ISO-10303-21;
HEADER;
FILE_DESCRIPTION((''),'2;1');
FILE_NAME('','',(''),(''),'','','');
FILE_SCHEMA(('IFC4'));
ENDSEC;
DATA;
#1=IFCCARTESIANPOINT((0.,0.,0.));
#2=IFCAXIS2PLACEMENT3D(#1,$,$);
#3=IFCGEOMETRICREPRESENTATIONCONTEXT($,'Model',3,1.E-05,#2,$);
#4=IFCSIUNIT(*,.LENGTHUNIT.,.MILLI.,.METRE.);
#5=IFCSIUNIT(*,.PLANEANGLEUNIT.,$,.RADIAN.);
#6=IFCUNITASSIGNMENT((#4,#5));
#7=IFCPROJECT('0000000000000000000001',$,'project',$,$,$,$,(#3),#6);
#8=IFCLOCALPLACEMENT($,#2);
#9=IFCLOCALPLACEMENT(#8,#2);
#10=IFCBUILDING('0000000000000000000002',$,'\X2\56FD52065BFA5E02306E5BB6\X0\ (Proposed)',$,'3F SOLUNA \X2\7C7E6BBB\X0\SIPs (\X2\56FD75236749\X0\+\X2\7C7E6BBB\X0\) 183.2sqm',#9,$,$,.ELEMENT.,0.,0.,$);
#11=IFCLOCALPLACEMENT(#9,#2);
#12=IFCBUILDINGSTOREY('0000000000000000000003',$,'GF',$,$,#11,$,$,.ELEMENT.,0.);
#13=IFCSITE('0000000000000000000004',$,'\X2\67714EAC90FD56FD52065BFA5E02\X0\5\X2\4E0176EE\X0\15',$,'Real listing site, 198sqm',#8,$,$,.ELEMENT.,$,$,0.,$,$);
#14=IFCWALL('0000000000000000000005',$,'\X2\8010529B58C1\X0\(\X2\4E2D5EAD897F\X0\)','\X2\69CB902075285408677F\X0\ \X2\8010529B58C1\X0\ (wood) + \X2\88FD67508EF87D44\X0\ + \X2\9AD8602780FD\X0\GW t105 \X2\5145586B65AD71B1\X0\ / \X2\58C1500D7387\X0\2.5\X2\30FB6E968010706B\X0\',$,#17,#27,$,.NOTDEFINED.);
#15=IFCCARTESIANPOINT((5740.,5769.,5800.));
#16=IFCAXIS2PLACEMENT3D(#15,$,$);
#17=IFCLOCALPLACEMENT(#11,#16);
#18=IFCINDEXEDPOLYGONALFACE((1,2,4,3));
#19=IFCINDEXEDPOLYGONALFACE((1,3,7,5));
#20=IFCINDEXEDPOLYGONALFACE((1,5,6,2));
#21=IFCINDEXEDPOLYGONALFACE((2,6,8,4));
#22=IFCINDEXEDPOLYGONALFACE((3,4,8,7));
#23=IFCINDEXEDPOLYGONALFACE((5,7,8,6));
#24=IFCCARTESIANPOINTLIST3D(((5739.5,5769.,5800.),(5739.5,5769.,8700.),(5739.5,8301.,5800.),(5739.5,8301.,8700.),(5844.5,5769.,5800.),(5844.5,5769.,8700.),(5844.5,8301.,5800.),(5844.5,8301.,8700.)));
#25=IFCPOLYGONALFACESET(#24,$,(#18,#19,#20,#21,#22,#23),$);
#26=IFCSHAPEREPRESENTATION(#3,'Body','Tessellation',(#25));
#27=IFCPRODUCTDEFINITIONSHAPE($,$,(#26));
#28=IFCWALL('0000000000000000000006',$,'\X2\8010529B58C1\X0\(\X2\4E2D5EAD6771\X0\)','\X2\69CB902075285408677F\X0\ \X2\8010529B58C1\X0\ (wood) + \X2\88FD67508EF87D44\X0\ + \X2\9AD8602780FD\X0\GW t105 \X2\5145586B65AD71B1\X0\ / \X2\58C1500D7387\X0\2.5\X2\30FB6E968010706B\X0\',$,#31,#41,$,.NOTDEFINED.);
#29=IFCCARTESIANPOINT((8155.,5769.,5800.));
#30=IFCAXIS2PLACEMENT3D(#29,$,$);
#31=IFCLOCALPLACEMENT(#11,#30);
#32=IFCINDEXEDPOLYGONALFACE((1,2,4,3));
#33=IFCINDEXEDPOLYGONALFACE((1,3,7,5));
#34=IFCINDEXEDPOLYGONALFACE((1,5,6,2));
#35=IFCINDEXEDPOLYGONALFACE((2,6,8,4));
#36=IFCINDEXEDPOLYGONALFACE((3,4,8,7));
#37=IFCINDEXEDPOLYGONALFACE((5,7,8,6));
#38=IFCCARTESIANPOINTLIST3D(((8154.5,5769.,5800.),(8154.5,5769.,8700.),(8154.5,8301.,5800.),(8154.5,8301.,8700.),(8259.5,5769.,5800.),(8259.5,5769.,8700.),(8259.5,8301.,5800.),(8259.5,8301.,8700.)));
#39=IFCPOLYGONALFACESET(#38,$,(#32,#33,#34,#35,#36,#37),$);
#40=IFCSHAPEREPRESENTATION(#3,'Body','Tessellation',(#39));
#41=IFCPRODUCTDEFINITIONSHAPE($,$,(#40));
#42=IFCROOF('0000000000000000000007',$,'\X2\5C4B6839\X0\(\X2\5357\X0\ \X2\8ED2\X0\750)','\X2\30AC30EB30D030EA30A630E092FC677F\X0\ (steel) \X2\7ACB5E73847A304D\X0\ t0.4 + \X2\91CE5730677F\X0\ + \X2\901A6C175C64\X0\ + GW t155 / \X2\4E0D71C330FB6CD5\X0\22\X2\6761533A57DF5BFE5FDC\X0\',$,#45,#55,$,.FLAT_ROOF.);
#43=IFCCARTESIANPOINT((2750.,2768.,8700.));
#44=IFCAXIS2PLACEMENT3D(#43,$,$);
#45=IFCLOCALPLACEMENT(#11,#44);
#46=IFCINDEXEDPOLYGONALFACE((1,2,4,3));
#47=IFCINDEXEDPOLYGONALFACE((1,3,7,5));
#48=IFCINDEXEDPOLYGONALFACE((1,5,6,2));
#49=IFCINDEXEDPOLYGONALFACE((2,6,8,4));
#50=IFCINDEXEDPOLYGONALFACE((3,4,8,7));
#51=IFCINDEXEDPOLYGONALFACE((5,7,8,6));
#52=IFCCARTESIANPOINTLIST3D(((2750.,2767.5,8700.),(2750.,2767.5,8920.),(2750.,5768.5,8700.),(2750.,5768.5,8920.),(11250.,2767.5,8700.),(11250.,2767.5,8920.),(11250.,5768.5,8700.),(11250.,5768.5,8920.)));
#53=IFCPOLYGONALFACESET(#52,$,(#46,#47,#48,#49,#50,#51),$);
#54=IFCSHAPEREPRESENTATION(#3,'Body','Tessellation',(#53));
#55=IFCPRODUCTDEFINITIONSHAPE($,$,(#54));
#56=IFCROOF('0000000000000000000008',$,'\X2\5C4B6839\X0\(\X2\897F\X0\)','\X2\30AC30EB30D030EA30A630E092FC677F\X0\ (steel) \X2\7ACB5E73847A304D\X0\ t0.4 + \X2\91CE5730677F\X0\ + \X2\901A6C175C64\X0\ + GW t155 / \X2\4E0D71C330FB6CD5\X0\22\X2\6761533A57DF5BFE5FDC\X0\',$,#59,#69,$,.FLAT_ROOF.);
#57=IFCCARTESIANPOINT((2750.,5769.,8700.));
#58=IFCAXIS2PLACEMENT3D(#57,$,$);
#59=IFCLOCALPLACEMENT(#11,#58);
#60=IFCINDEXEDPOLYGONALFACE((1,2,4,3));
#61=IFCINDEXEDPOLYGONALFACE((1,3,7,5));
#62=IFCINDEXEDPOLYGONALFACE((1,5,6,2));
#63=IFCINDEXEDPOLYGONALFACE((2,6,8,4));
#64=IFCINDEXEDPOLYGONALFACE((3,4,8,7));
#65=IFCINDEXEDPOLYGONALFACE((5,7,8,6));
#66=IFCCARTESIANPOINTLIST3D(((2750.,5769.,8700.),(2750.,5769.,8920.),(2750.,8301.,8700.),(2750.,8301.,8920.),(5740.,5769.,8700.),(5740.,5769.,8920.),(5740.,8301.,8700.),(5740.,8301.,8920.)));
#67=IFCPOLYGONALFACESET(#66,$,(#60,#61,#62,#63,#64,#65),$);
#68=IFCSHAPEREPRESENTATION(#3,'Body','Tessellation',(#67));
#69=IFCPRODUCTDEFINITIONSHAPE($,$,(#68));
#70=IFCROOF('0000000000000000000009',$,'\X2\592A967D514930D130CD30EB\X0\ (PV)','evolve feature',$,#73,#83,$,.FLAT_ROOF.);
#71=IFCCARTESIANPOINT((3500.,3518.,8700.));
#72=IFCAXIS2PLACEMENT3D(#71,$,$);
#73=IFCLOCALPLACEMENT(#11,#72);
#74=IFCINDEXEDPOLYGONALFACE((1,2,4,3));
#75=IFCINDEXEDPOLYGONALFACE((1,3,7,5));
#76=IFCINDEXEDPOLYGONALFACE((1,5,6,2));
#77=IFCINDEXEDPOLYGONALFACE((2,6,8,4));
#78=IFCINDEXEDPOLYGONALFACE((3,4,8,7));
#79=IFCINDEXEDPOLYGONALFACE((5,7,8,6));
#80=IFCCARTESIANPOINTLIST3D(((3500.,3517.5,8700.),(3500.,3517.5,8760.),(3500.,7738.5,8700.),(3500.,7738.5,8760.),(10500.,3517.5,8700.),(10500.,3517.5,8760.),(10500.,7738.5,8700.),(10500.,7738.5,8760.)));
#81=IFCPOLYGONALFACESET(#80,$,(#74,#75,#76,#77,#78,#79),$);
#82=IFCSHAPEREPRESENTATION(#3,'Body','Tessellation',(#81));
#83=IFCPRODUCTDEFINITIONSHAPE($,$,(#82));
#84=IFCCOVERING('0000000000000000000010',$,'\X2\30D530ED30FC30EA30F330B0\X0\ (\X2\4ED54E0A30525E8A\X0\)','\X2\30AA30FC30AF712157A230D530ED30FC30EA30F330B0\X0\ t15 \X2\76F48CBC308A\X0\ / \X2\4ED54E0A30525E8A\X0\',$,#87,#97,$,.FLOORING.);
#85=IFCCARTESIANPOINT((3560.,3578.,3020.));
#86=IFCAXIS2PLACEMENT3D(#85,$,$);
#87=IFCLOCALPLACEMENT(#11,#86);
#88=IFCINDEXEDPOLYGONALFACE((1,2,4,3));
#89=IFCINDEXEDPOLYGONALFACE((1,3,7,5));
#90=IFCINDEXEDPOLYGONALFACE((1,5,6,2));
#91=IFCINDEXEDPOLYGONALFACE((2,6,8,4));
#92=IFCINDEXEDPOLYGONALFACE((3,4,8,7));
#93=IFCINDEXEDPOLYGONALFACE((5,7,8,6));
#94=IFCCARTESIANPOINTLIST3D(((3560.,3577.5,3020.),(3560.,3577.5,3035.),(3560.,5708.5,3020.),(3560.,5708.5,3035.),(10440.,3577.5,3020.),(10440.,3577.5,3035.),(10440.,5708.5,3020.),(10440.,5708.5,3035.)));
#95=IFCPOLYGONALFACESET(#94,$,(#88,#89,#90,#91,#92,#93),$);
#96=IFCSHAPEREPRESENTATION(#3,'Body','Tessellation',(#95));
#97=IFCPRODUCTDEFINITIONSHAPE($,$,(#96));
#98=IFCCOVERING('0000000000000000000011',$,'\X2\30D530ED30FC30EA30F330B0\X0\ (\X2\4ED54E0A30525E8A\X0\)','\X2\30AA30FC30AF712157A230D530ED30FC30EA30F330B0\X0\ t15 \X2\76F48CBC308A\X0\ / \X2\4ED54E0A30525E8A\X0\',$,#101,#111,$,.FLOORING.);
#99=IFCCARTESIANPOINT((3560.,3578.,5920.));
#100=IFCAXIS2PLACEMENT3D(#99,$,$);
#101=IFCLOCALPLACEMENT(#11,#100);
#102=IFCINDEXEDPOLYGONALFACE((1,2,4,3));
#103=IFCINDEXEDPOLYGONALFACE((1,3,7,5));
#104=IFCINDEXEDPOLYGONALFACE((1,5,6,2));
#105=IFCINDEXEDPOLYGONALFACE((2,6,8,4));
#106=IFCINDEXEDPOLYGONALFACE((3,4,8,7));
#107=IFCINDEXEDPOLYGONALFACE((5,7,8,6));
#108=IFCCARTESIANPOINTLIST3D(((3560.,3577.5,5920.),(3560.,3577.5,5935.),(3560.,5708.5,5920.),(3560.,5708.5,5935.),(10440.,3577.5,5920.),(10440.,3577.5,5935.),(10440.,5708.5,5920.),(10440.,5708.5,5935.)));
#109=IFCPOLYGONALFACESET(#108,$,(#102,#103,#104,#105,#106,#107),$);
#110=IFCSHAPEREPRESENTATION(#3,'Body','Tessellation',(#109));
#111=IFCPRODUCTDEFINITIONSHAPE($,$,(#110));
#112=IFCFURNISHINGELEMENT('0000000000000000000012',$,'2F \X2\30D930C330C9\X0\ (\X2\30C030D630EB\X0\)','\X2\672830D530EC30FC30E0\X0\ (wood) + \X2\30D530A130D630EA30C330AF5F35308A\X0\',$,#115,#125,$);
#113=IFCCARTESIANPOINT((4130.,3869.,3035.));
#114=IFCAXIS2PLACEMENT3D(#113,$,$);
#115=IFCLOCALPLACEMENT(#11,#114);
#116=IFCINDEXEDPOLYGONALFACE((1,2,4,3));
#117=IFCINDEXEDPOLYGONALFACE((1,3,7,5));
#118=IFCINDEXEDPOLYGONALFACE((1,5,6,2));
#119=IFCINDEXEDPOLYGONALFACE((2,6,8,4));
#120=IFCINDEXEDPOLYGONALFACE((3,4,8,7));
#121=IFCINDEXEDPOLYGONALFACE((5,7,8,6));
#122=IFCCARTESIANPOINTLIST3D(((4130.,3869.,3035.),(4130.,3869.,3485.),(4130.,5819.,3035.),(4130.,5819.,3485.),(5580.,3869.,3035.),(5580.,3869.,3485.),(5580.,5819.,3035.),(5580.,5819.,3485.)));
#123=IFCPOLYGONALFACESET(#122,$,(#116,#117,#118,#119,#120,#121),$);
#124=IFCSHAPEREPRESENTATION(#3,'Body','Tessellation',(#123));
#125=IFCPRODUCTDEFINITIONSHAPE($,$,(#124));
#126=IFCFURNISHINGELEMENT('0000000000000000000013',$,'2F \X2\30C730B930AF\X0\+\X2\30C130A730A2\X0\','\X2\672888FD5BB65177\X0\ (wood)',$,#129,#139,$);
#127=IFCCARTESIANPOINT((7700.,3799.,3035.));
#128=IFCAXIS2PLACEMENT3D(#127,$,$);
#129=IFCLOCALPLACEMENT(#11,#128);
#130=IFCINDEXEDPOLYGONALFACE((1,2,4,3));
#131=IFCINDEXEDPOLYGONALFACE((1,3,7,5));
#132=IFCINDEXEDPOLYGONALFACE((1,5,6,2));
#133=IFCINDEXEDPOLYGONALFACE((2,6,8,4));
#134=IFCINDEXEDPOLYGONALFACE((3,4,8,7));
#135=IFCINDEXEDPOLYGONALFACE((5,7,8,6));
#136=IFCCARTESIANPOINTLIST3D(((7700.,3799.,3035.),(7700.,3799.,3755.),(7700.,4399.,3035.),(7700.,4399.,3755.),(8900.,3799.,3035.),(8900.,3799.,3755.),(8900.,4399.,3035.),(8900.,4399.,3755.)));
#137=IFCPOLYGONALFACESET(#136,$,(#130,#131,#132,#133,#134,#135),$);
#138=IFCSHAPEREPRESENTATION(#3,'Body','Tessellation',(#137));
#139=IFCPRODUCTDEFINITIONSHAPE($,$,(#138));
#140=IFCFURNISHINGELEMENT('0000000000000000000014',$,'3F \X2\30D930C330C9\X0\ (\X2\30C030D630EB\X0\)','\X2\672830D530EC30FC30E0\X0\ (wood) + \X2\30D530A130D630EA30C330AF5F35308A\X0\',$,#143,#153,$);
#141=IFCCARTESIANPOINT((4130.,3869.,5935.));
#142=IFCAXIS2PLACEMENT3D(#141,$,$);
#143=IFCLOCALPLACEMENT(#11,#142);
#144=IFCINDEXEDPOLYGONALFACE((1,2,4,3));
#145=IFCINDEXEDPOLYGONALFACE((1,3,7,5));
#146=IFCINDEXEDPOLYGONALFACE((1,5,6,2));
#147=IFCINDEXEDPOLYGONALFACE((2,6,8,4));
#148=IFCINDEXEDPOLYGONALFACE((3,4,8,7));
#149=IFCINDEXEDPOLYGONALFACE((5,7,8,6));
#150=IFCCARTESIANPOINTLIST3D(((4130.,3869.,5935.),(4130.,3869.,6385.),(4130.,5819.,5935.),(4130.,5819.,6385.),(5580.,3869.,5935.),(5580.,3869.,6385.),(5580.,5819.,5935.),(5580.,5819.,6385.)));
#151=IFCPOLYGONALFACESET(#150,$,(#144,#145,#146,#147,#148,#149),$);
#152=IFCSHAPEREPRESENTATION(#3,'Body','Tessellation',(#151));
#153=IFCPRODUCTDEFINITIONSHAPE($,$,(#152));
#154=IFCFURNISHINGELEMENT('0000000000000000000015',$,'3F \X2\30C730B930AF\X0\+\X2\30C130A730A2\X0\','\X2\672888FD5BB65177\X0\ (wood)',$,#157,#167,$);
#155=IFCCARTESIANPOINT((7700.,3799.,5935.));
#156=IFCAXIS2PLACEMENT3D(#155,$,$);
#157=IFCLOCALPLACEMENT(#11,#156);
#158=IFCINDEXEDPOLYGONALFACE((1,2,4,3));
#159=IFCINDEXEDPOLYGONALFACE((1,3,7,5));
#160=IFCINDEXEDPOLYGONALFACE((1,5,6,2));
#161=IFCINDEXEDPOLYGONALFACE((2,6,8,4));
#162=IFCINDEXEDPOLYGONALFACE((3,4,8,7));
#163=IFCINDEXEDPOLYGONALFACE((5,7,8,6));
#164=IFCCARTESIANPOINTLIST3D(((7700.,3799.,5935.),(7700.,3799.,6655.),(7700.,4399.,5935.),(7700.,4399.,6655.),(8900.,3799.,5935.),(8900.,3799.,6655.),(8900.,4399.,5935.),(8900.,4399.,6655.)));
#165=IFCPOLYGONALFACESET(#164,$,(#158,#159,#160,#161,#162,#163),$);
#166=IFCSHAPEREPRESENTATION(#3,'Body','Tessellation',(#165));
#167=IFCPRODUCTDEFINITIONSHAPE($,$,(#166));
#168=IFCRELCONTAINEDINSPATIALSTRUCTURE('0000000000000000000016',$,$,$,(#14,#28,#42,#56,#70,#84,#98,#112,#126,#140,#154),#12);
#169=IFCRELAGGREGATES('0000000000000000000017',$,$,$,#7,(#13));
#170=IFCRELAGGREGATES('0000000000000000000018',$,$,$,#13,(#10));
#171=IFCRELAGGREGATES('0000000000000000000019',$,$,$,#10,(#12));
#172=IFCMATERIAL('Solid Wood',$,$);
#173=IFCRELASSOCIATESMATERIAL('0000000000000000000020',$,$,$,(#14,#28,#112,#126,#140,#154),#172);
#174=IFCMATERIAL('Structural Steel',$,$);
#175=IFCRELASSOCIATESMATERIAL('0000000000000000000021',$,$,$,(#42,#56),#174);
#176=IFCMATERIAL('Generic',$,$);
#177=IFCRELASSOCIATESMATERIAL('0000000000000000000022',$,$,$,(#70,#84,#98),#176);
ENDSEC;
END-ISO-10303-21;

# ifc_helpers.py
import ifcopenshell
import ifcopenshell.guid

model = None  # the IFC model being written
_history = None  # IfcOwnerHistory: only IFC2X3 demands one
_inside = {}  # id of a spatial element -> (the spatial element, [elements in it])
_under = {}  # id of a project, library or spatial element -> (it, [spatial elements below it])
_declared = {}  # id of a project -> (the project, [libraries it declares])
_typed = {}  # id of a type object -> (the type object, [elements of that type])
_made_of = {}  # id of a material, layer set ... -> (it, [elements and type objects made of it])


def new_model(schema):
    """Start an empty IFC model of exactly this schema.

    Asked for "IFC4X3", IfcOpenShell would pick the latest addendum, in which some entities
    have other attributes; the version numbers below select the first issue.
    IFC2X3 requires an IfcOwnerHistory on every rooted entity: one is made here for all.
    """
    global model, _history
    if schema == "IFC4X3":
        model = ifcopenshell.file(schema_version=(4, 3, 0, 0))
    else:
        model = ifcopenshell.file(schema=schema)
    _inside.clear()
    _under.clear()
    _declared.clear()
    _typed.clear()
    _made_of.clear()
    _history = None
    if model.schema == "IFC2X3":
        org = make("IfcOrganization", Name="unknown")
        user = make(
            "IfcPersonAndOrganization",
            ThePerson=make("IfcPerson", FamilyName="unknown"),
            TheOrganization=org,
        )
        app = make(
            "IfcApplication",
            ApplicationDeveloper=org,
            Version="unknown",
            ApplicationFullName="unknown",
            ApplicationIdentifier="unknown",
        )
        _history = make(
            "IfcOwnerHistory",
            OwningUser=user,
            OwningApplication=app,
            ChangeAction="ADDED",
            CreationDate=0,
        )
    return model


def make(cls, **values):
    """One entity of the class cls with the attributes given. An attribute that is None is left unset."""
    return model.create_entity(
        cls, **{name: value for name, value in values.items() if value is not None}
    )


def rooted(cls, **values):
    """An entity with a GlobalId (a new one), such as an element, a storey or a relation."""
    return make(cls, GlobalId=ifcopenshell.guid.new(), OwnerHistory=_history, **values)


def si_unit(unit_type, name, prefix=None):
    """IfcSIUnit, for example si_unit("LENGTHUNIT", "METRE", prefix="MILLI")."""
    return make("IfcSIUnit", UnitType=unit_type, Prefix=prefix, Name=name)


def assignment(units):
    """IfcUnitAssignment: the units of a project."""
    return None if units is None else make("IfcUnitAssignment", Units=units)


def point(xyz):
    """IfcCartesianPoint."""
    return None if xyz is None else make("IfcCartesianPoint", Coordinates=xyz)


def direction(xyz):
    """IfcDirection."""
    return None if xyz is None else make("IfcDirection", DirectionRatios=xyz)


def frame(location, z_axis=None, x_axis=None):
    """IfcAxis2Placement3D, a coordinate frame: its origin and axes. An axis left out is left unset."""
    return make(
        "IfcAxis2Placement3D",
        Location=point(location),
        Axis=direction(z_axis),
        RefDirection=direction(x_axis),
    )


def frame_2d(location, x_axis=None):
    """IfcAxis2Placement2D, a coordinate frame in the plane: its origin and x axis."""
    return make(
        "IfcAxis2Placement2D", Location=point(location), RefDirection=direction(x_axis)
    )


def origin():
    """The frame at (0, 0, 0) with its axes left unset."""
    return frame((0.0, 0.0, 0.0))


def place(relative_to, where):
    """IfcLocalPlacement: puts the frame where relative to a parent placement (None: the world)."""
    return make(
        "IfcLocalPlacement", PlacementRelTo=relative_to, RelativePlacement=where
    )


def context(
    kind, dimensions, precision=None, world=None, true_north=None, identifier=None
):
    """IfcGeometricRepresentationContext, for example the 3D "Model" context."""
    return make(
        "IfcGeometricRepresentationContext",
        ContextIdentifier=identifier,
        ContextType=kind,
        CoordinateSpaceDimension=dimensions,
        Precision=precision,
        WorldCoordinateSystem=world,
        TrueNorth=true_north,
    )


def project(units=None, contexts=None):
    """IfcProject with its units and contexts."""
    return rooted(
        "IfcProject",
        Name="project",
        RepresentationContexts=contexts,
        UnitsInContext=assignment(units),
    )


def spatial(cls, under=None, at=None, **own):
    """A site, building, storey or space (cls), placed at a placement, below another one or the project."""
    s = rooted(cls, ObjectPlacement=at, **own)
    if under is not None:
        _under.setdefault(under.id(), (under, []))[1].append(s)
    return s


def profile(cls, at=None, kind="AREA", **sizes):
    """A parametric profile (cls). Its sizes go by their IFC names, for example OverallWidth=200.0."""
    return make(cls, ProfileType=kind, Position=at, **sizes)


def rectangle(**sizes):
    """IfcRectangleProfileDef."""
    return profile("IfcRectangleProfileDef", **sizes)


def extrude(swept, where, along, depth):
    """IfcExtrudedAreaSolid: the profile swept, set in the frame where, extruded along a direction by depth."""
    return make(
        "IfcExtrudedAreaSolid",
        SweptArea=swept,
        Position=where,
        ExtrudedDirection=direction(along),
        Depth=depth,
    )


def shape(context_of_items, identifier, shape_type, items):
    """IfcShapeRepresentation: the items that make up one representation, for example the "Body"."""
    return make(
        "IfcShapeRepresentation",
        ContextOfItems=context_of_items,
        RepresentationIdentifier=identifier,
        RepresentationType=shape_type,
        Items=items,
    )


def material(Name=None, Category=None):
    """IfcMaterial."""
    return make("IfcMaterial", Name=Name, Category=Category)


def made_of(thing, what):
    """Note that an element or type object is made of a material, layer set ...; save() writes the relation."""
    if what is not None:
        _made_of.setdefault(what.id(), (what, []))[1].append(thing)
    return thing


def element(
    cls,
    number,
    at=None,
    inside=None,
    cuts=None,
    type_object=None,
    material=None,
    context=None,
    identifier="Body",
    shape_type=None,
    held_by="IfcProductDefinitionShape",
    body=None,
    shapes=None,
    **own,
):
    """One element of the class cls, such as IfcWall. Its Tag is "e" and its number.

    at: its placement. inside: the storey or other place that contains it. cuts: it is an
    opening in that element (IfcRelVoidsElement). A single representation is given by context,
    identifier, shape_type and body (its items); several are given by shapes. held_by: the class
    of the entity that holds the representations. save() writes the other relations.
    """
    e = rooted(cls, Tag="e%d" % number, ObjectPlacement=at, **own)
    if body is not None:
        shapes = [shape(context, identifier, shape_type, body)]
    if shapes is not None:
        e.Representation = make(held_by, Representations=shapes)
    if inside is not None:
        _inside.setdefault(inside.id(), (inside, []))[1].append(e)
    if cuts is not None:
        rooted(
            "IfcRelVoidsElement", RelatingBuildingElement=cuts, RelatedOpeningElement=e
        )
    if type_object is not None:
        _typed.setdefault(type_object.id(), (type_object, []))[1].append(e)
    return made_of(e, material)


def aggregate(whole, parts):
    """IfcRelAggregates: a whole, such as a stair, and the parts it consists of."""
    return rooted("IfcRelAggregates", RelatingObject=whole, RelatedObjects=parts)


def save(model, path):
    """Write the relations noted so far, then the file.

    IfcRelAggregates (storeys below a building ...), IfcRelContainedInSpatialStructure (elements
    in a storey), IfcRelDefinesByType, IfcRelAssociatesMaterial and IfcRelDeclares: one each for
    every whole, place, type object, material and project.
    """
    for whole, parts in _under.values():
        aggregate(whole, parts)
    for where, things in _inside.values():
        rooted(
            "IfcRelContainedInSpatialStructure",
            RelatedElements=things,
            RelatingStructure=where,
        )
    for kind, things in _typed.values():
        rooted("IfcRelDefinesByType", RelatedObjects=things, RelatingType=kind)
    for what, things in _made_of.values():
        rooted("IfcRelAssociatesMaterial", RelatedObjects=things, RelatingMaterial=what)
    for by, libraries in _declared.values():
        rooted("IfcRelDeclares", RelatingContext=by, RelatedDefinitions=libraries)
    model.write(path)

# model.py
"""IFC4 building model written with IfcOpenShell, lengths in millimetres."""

from ifc_helpers import new_model, si_unit, frame, frame_2d, origin, place, context, project, spatial, rectangle, extrude, material, element, save


model = new_model("IFC4")

# Units and contexts
model_context = context("Model", 3, precision=1e-05, world=origin())
ifc_project = project(units=[si_unit("LENGTHUNIT", "METRE", prefix="MILLI"), si_unit("PLANEANGLEUNIT", "RADIAN")], contexts=[model_context])

# Site, building, storey
site_placement = place(None, origin())
site = spatial("IfcSite", under=ifc_project, at=site_placement, Name="東京都国分寺市5丁目15", ObjectType="Real listing site, 198sqm", CompositionType="ELEMENT", RefElevation=0.0)
building_placement = place(site_placement, origin())
building = spatial("IfcBuilding", under=site, at=building_placement, Name="国分寺市の家 (Proposed)", ObjectType="3F SOLUNA 籾殻SIPs (国産杉+籾殻) 183.2sqm", CompositionType="ELEMENT", ElevationOfRefHeight=0.0, ElevationOfTerrain=0.0)
storey_placement = place(building_placement, origin())
storey = spatial("IfcBuildingStorey", under=building, at=storey_placement, Name="GF", CompositionType="ELEMENT", Elevation=0.0)

# Shared definitions
ifc_material_1 = material(Name="Solid Wood")

# Walls
wall_1_placement = place(storey_placement, frame((5740.0, 5769.0, 5800.0)))
element("IfcWall", 1, at=wall_1_placement, inside=storey, material=ifc_material_1, Name="耐力壁(中庭西)", Description="構造用合板 耐力壁 (wood) + 製材軸組 + 高性能GW t105 充填断熱 / 壁倍率2.5・準耐火", PredefinedType="NOTDEFINED", context=model_context, shape_type="SweptSolid", body=[
    extrude(rectangle(XDim=105.0, YDim=2532.0, at=frame_2d((52.0, 1266.0))), frame((5740.0, 5769.0, 5800.0)), (0.0, 0.0, 1.0), 2900.0),
])
wall_2_placement = place(storey_placement, frame((8155.0, 5769.0, 5800.0)))
element("IfcWall", 2, at=wall_2_placement, inside=storey, material=ifc_material_1, Name="耐力壁(中庭東)", Description="構造用合板 耐力壁 (wood) + 製材軸組 + 高性能GW t105 充填断熱 / 壁倍率2.5・準耐火", PredefinedType="NOTDEFINED", context=model_context, shape_type="SweptSolid", body=[
    extrude(rectangle(XDim=105.0, YDim=2532.0, at=frame_2d((52.0, 1266.0))), frame((8155.0, 5769.0, 5800.0)), (0.0, 0.0, 1.0), 2900.0),
])

# Roofs
ifc_material_2 = material(Name="Structural Steel")
roof_1_placement = place(storey_placement, frame((2750.0, 2768.0, 8700.0)))
element("IfcRoof", 3, at=roof_1_placement, inside=storey, material=ifc_material_2, Name="屋根(南 軒750)", Description="ガルバリウム鋼板 (steel) 立平葺き t0.4 + 野地板 + 通気層 + GW t155 / 不燃・法22条区域対応", PredefinedType="FLAT_ROOF", context=model_context, shape_type="SweptSolid", body=[
    extrude(rectangle(XDim=8500.0, YDim=3001.0, at=frame_2d((4250.0, 1500.0))), frame((2750.0, 2768.0, 8700.0)), (0.0, 0.0, 1.0), 220.0),
])
roof_2_placement = place(storey_placement, frame((2750.0, 5769.0, 8700.0)))
element("IfcRoof", 4, at=roof_2_placement, inside=storey, material=ifc_material_2, Name="屋根(西)", Description="ガルバリウム鋼板 (steel) 立平葺き t0.4 + 野地板 + 通気層 + GW t155 / 不燃・法22条区域対応", PredefinedType="FLAT_ROOF", context=model_context, shape_type="SweptSolid", body=[
    extrude(rectangle(XDim=2990.0, YDim=2532.0, at=frame_2d((1495.0, 1266.0))), frame((2750.0, 5769.0, 8700.0)), (0.0, 0.0, 1.0), 220.0),
])
ifc_material_3 = material(Name="Generic")
roof_3_placement = place(storey_placement, frame((3500.0, 3518.0, 8700.0)))
element("IfcRoof", 5, at=roof_3_placement, inside=storey, material=ifc_material_3, Name="太陽光パネル (PV)", Description="evolve feature", PredefinedType="FLAT_ROOF", context=model_context, shape_type="SweptSolid", body=[
    extrude(rectangle(XDim=7000.0, YDim=4221.0, at=frame_2d((3500.0, 2110.0))), frame((3500.0, 3518.0, 8700.0)), (0.0, 0.0, 1.0), 60.0),
])

# Coverings
covering_1_placement = place(storey_placement, frame((3560.0, 3578.0, 3020.0)))
element("IfcCovering", 6, at=covering_1_placement, inside=storey, material=ifc_material_3, Name="フローリング (仕上げ床)", Description="オーク無垢フローリング t15 直貼り / 仕上げ床", PredefinedType="FLOORING", context=model_context, shape_type="SweptSolid", body=[
    extrude(rectangle(XDim=6880.0, YDim=2131.0, at=frame_2d((3440.0, 1065.0))), frame((3560.0, 3578.0, 3020.0)), (0.0, 0.0, 1.0), 15.0),
])
covering_2_placement = place(storey_placement, frame((3560.0, 3578.0, 5920.0)))
element("IfcCovering", 7, at=covering_2_placement, inside=storey, material=ifc_material_3, Name="フローリング (仕上げ床)", Description="オーク無垢フローリング t15 直貼り / 仕上げ床", PredefinedType="FLOORING", context=model_context, shape_type="SweptSolid", body=[
    extrude(rectangle(XDim=6880.0, YDim=2131.0, at=frame_2d((3440.0, 1065.0))), frame((3560.0, 3578.0, 5920.0)), (0.0, 0.0, 1.0), 15.0),
])

# Furnishing elements
furnishing_1_placement = place(storey_placement, frame((4130.0, 3869.0, 3035.0)))
element("IfcFurnishingElement", 8, at=furnishing_1_placement, inside=storey, material=ifc_material_1, Name="2F ベッド (ダブル)", Description="木フレーム (wood) + ファブリック張り", context=model_context, shape_type="SweptSolid", body=[
    extrude(rectangle(XDim=1450.0, YDim=1950.0, at=frame_2d((725.0, 975.0))), frame((4130.0, 3869.0, 3035.0)), (0.0, 0.0, 1.0), 450.0),
])
furnishing_2_placement = place(storey_placement, frame((7700.0, 3799.0, 3035.0)))
element("IfcFurnishingElement", 9, at=furnishing_2_placement, inside=storey, material=ifc_material_1, Name="2F デスク+チェア", Description="木製家具 (wood)", context=model_context, shape_type="SweptSolid", body=[
    extrude(rectangle(XDim=1200.0, YDim=600.0, at=frame_2d((600.0, 300.0))), frame((7700.0, 3799.0, 3035.0)), (0.0, 0.0, 1.0), 720.0),
])
furnishing_3_placement = place(storey_placement, frame((4130.0, 3869.0, 5935.0)))
element("IfcFurnishingElement", 10, at=furnishing_3_placement, inside=storey, material=ifc_material_1, Name="3F ベッド (ダブル)", Description="木フレーム (wood) + ファブリック張り", context=model_context, shape_type="SweptSolid", body=[
    extrude(rectangle(XDim=1450.0, YDim=1950.0, at=frame_2d((725.0, 975.0))), frame((4130.0, 3869.0, 5935.0)), (0.0, 0.0, 1.0), 450.0),
])
furnishing_4_placement = place(storey_placement, frame((7700.0, 3799.0, 5935.0)))
element("IfcFurnishingElement", 11, at=furnishing_4_placement, inside=storey, material=ifc_material_1, Name="3F デスク+チェア", Description="木製家具 (wood)", context=model_context, shape_type="SweptSolid", body=[
    extrude(rectangle(XDim=1200.0, YDim=600.0, at=frame_2d((600.0, 300.0))), frame((7700.0, 3799.0, 5935.0)), (0.0, 0.0, 1.0), 720.0),
])

save(model, "model.ifc")
